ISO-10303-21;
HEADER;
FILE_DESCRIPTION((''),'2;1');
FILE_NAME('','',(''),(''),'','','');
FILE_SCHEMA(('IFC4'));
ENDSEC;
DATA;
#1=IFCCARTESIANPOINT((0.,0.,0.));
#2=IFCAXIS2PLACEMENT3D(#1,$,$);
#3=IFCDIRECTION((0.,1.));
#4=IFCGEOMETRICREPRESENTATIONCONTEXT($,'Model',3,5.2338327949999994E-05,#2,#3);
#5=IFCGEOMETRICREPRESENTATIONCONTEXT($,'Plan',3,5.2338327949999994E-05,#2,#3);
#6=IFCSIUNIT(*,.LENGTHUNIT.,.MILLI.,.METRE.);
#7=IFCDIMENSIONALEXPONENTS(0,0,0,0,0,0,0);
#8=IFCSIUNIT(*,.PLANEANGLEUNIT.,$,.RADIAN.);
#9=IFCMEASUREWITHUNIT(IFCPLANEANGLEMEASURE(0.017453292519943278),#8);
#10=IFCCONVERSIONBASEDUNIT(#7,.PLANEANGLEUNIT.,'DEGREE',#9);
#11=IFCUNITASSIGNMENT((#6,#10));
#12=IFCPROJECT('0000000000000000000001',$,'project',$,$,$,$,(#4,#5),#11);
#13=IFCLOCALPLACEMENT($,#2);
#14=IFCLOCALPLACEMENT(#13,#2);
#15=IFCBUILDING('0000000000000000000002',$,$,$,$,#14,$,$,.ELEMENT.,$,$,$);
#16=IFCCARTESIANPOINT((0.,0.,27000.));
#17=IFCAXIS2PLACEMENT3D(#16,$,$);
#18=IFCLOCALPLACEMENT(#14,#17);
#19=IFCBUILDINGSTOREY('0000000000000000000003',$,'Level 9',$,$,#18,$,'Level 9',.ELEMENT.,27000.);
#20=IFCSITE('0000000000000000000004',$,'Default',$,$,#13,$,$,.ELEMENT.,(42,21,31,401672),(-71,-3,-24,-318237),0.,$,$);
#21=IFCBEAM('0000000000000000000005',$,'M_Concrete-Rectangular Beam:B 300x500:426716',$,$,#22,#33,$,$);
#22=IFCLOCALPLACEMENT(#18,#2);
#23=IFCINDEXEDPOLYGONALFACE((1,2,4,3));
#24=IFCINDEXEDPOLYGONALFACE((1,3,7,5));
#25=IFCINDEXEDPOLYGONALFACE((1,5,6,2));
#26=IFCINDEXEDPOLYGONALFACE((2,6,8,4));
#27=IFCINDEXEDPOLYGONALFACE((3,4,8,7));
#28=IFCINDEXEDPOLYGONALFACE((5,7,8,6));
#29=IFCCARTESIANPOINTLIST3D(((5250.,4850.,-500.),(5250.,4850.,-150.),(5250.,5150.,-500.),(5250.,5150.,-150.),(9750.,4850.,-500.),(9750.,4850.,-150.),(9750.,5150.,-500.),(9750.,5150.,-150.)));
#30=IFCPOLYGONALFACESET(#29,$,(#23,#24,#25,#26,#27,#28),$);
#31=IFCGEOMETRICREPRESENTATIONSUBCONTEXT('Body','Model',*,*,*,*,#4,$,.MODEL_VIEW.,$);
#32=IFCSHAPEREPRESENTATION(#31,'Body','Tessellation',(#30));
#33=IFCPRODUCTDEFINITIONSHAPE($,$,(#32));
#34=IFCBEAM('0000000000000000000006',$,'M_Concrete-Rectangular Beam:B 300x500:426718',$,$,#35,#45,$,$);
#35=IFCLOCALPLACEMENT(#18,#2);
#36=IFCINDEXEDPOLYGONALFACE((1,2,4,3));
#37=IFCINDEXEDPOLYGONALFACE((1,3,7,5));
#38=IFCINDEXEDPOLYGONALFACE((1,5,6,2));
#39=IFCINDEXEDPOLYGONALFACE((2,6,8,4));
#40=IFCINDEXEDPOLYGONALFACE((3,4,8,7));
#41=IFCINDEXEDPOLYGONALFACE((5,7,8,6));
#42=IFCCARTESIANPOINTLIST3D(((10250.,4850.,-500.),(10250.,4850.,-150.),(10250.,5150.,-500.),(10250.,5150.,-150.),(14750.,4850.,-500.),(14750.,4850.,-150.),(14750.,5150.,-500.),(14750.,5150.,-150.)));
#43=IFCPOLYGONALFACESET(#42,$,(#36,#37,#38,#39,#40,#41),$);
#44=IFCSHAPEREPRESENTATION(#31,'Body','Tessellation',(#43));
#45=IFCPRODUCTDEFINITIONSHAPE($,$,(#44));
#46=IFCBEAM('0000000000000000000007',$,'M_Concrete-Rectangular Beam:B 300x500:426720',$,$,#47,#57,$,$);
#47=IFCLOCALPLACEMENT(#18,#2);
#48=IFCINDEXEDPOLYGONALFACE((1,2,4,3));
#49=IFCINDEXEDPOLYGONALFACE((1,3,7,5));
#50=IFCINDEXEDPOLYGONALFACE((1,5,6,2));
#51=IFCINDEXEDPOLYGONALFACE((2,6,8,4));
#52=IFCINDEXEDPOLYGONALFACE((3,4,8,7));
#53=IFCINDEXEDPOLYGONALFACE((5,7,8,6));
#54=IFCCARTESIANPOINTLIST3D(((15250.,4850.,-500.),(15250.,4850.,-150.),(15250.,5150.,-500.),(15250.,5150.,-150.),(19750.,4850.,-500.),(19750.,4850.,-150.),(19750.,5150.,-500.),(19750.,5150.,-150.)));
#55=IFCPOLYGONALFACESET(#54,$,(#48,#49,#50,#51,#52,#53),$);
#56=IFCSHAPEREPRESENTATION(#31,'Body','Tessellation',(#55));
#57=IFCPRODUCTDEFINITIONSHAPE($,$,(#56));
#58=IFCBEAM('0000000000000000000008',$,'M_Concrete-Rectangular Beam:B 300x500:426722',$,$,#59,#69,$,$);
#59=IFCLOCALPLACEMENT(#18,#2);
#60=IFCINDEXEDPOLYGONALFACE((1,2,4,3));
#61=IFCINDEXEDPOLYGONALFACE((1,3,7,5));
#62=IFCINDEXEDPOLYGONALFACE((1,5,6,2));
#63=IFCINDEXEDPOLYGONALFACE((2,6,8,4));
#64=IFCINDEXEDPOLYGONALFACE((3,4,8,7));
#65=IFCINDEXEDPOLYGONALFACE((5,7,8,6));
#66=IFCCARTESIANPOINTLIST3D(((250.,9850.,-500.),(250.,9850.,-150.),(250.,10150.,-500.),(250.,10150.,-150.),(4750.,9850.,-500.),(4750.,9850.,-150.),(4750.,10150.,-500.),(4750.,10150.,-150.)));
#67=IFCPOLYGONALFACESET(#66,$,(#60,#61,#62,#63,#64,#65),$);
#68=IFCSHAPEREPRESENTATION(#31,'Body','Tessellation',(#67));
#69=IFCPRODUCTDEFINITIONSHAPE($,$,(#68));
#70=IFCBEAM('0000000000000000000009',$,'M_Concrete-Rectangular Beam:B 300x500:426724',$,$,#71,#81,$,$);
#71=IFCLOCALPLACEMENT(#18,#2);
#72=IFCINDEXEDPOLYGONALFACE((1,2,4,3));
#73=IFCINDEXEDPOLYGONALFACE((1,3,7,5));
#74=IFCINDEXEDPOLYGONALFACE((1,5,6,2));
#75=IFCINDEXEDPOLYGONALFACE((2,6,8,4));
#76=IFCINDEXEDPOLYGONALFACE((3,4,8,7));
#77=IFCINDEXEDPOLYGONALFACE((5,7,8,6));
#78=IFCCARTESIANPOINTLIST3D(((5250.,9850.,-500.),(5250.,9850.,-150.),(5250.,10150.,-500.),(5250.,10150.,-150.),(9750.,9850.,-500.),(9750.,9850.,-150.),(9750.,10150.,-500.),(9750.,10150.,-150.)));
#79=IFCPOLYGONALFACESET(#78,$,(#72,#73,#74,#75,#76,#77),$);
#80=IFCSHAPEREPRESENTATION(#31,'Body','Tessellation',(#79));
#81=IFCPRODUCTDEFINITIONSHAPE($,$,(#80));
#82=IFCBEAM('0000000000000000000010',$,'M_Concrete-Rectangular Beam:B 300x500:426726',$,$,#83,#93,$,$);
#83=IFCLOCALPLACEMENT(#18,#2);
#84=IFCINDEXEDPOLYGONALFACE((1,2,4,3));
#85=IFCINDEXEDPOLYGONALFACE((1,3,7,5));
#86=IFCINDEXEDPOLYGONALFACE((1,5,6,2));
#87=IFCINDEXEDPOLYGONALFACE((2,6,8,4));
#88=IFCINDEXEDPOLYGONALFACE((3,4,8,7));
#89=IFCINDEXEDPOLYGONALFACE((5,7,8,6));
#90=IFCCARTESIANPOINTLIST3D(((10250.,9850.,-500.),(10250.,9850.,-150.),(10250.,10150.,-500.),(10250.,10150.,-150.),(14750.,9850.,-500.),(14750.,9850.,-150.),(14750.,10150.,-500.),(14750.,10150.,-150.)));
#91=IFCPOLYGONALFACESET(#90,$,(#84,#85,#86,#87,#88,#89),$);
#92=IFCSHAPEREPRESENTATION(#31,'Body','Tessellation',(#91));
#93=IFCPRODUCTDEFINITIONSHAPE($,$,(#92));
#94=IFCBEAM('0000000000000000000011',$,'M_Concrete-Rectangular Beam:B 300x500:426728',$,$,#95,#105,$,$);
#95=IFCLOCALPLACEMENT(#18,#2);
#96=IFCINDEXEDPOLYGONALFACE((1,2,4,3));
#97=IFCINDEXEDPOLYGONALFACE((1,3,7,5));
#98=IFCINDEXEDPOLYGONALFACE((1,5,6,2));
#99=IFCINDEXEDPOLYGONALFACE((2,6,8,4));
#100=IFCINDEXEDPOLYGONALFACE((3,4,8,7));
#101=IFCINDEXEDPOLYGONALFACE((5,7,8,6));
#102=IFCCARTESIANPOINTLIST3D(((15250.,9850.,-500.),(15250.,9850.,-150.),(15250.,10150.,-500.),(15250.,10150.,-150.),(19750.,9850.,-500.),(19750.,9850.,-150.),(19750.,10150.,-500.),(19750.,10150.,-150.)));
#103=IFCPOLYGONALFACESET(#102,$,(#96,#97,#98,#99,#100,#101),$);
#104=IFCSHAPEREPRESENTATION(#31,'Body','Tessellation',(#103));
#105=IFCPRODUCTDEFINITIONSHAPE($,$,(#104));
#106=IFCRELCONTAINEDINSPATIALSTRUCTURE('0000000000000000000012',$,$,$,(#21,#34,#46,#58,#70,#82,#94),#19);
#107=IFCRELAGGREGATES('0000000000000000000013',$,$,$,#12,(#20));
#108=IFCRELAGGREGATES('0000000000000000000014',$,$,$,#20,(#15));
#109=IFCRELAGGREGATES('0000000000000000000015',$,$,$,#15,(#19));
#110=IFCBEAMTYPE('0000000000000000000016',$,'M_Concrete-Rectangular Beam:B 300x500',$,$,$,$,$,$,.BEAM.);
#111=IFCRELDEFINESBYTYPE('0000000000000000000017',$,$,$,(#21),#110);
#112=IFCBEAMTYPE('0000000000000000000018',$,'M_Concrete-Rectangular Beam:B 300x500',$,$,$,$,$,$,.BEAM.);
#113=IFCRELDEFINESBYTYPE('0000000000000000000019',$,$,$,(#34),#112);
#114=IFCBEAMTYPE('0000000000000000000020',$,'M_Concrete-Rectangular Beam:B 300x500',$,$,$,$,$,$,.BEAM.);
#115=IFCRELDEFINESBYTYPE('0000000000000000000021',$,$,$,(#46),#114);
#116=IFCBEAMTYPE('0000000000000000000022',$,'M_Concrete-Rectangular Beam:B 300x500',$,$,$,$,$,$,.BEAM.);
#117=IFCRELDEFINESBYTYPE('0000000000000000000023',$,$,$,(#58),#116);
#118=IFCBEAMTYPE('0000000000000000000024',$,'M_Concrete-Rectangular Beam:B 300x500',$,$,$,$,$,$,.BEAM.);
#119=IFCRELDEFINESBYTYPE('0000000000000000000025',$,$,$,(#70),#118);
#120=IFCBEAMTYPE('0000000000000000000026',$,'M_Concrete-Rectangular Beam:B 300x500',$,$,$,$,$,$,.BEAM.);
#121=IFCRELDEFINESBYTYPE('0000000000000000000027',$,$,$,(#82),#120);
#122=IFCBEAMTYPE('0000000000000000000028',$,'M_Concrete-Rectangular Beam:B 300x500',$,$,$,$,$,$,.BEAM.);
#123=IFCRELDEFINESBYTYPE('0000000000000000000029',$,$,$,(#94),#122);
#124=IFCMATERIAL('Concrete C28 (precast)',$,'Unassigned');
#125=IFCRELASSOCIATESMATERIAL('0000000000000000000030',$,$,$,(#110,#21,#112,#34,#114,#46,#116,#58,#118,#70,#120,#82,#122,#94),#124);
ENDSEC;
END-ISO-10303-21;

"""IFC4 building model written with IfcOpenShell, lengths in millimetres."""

from ifc_helpers import new_model, entity, si_unit, converted_unit, direction, frame, origin, place, context, subcontext, project, spatial, indexed_curve, outline, extrude, source, transform, mapped, material, type_object, type_shapes, element, save


model = new_model("IFC4")

# Units and contexts
model_context = context("Model", 3, precision=5.2338327949999994e-05, world=origin(), true_north=direction((0.0, 1.0)))
plan_context = context("Plan", 3, precision=5.2338327949999994e-05, world=origin(), true_north=direction((0.0, 1.0)))
body_context = subcontext(model_context, "Body", "Model", "MODEL_VIEW")
ifc_project = project(units=[si_unit("LENGTHUNIT", "METRE", prefix="MILLI"), converted_unit("PLANEANGLEUNIT", "DEGREE", entity("IfcPlaneAngleMeasure", 0.017453292519943278), si_unit("PLANEANGLEUNIT", "RADIAN"), dimensions=[0, 0, 0, 0, 0, 0, 0])], contexts=[model_context, plan_context])

# Site, building, storey
site_placement = place(None, origin())
site = spatial("IfcSite", under=ifc_project, at=site_placement, Name="Default", CompositionType="ELEMENT", RefLatitude=(42, 21, 31, 401672), RefLongitude=(-71, -3, -24, -318237), RefElevation=0.0)
building_placement = place(site_placement, origin())
building = spatial("IfcBuilding", under=site, at=building_placement, CompositionType="ELEMENT")
storey_placement = place(building_placement, frame((0.0, 0.0, 27000.0)))
storey = spatial("IfcBuildingStorey", under=building, at=storey_placement, Name="Level 9", LongName="Level 9", CompositionType="ELEMENT", Elevation=27000.0)

# Shared definitions
ifc_material = material(Name="Concrete C28 (precast)", Category="Unassigned")

# Beams
beam_type_1 = type_object("IfcBeamType", Name="M_Concrete-Rectangular Beam:B 300x500", PredefinedType="BEAM", material=ifc_material)
shared_shape_1 = source(origin(), body_context, "Body", "SweptSolid", [
    extrude(outline(indexed_curve([(-175.0, -150.0), (175.0, -150.0), (175.0, 150.0), (-175.0, 150.0), (-175.0, -150.0)], self_intersect=False)), frame((5250.0, 5000.0, 26675.0), z_axis=(1.0, 0.0, 0.0), x_axis=(0.0, 0.0, -1.0)), (0.0, 0.0, 1.0), 4500.0),
])
type_shapes(beam_type_1, [shared_shape_1])
beam_1_placement = place(storey_placement, frame((0.0, 0.0, -27000.0)))
element("IfcBeam", 1, at=beam_1_placement, inside=storey, type_object=beam_type_1, material=ifc_material, Name="M_Concrete-Rectangular Beam:B 300x500:426716", context=body_context, shape_type="MappedRepresentation", body=[
    mapped(shared_shape_1, transform((0.0, 0.0, 0.0), scale=1.0)),
])
beam_type_2 = type_object("IfcBeamType", Name="M_Concrete-Rectangular Beam:B 300x500", PredefinedType="BEAM", material=ifc_material)
shared_shape_2 = source(origin(), body_context, "Body", "SweptSolid", [
    extrude(outline(indexed_curve([(-175.0, -150.0), (175.0, -150.0), (175.0, 150.0), (-175.0, 150.0), (-175.0, -150.0)], self_intersect=False)), frame((10250.0, 5000.0, 26675.0), z_axis=(1.0, 0.0, 0.0), x_axis=(0.0, 0.0, -1.0)), (0.0, 0.0, 1.0), 4500.0),
])
type_shapes(beam_type_2, [shared_shape_2])
beam_2_placement = place(storey_placement, frame((0.0, 0.0, -27000.0)))
element("IfcBeam", 2, at=beam_2_placement, inside=storey, type_object=beam_type_2, material=ifc_material, Name="M_Concrete-Rectangular Beam:B 300x500:426718", context=body_context, shape_type="MappedRepresentation", body=[
    mapped(shared_shape_2, transform((0.0, 0.0, 0.0), scale=1.0)),
])
beam_type_3 = type_object("IfcBeamType", Name="M_Concrete-Rectangular Beam:B 300x500", PredefinedType="BEAM", material=ifc_material)
shared_shape_3 = source(origin(), body_context, "Body", "SweptSolid", [
    extrude(outline(indexed_curve([(-175.0, -150.0), (175.0, -150.0), (175.0, 150.0), (-175.0, 150.0), (-175.0, -150.0)], self_intersect=False)), frame((15250.0, 5000.0, 26675.0), z_axis=(1.0, 0.0, 0.0), x_axis=(0.0, 0.0, -1.0)), (0.0, 0.0, 1.0), 4500.0),
])
type_shapes(beam_type_3, [shared_shape_3])
beam_3_placement = place(storey_placement, frame((0.0, 0.0, -27000.0)))
element("IfcBeam", 3, at=beam_3_placement, inside=storey, type_object=beam_type_3, material=ifc_material, Name="M_Concrete-Rectangular Beam:B 300x500:426720", context=body_context, shape_type="MappedRepresentation", body=[
    mapped(shared_shape_3, transform((0.0, 0.0, 0.0), scale=1.0)),
])
beam_type_4 = type_object("IfcBeamType", Name="M_Concrete-Rectangular Beam:B 300x500", PredefinedType="BEAM", material=ifc_material)
shared_shape_4 = source(origin(), body_context, "Body", "SweptSolid", [
    extrude(outline(indexed_curve([(-175.0, -150.0), (175.0, -150.0), (175.0, 150.0), (-175.0, 150.0), (-175.0, -150.0)], self_intersect=False)), frame((250.0, 10000.0, 26675.0), z_axis=(1.0, 0.0, 0.0), x_axis=(0.0, 0.0, -1.0)), (0.0, 0.0, 1.0), 4500.0),
])
type_shapes(beam_type_4, [shared_shape_4])
beam_4_placement = place(storey_placement, frame((0.0, 0.0, -27000.0)))
element("IfcBeam", 4, at=beam_4_placement, inside=storey, type_object=beam_type_4, material=ifc_material, Name="M_Concrete-Rectangular Beam:B 300x500:426722", context=body_context, shape_type="MappedRepresentation", body=[
    mapped(shared_shape_4, transform((0.0, 0.0, 0.0), scale=1.0)),
])
beam_type_5 = type_object("IfcBeamType", Name="M_Concrete-Rectangular Beam:B 300x500", PredefinedType="BEAM", material=ifc_material)
shared_shape_5 = source(origin(), body_context, "Body", "SweptSolid", [
    extrude(outline(indexed_curve([(-175.0, -150.0), (175.0, -150.0), (175.0, 150.0), (-175.0, 150.0), (-175.0, -150.0)], self_intersect=False)), frame((5250.0, 10000.0, 26675.0), z_axis=(1.0, 0.0, 0.0), x_axis=(0.0, 0.0, -1.0)), (0.0, 0.0, 1.0), 4500.0),
])
type_shapes(beam_type_5, [shared_shape_5])
beam_5_placement = place(storey_placement, frame((0.0, 0.0, -27000.0)))
element("IfcBeam", 5, at=beam_5_placement, inside=storey, type_object=beam_type_5, material=ifc_material, Name="M_Concrete-Rectangular Beam:B 300x500:426724", context=body_context, shape_type="MappedRepresentation", body=[
    mapped(shared_shape_5, transform((0.0, 0.0, 0.0), scale=1.0)),
])
beam_type_6 = type_object("IfcBeamType", Name="M_Concrete-Rectangular Beam:B 300x500", PredefinedType="BEAM", material=ifc_material)
shared_shape_6 = source(origin(), body_context, "Body", "SweptSolid", [
    extrude(outline(indexed_curve([(-175.0, -150.0), (175.0, -150.0), (175.0, 150.0), (-175.0, 150.0), (-175.0, -150.0)], self_intersect=False)), frame((10250.0, 10000.0, 26675.0), z_axis=(1.0, 0.0, 0.0), x_axis=(0.0, 0.0, -1.0)), (0.0, 0.0, 1.0), 4500.0),
])
type_shapes(beam_type_6, [shared_shape_6])
beam_6_placement = place(storey_placement, frame((0.0, 0.0, -27000.0)))
element("IfcBeam", 6, at=beam_6_placement, inside=storey, type_object=beam_type_6, material=ifc_material, Name="M_Concrete-Rectangular Beam:B 300x500:426726", context=body_context, shape_type="MappedRepresentation", body=[
    mapped(shared_shape_6, transform((0.0, 0.0, 0.0), scale=1.0)),
])
beam_type_7 = type_object("IfcBeamType", Name="M_Concrete-Rectangular Beam:B 300x500", PredefinedType="BEAM", material=ifc_material)
shared_shape_7 = source(origin(), body_context, "Body", "SweptSolid", [
    extrude(outline(indexed_curve([(-175.0, -150.0), (175.0, -150.0), (175.0, 150.0), (-175.0, 150.0), (-175.0, -150.0)], self_intersect=False)), frame((15250.0, 10000.0, 26675.0), z_axis=(1.0, 0.0, 0.0), x_axis=(0.0, 0.0, -1.0)), (0.0, 0.0, 1.0), 4500.0),
])
type_shapes(beam_type_7, [shared_shape_7])
beam_7_placement = place(storey_placement, frame((0.0, 0.0, -27000.0)))
element("IfcBeam", 7, at=beam_7_placement, inside=storey, type_object=beam_type_7, material=ifc_material, Name="M_Concrete-Rectangular Beam:B 300x500:426728", context=body_context, shape_type="MappedRepresentation", body=[
    mapped(shared_shape_7, transform((0.0, 0.0, 0.0), scale=1.0)),
])

save(model, "model.ifc")
